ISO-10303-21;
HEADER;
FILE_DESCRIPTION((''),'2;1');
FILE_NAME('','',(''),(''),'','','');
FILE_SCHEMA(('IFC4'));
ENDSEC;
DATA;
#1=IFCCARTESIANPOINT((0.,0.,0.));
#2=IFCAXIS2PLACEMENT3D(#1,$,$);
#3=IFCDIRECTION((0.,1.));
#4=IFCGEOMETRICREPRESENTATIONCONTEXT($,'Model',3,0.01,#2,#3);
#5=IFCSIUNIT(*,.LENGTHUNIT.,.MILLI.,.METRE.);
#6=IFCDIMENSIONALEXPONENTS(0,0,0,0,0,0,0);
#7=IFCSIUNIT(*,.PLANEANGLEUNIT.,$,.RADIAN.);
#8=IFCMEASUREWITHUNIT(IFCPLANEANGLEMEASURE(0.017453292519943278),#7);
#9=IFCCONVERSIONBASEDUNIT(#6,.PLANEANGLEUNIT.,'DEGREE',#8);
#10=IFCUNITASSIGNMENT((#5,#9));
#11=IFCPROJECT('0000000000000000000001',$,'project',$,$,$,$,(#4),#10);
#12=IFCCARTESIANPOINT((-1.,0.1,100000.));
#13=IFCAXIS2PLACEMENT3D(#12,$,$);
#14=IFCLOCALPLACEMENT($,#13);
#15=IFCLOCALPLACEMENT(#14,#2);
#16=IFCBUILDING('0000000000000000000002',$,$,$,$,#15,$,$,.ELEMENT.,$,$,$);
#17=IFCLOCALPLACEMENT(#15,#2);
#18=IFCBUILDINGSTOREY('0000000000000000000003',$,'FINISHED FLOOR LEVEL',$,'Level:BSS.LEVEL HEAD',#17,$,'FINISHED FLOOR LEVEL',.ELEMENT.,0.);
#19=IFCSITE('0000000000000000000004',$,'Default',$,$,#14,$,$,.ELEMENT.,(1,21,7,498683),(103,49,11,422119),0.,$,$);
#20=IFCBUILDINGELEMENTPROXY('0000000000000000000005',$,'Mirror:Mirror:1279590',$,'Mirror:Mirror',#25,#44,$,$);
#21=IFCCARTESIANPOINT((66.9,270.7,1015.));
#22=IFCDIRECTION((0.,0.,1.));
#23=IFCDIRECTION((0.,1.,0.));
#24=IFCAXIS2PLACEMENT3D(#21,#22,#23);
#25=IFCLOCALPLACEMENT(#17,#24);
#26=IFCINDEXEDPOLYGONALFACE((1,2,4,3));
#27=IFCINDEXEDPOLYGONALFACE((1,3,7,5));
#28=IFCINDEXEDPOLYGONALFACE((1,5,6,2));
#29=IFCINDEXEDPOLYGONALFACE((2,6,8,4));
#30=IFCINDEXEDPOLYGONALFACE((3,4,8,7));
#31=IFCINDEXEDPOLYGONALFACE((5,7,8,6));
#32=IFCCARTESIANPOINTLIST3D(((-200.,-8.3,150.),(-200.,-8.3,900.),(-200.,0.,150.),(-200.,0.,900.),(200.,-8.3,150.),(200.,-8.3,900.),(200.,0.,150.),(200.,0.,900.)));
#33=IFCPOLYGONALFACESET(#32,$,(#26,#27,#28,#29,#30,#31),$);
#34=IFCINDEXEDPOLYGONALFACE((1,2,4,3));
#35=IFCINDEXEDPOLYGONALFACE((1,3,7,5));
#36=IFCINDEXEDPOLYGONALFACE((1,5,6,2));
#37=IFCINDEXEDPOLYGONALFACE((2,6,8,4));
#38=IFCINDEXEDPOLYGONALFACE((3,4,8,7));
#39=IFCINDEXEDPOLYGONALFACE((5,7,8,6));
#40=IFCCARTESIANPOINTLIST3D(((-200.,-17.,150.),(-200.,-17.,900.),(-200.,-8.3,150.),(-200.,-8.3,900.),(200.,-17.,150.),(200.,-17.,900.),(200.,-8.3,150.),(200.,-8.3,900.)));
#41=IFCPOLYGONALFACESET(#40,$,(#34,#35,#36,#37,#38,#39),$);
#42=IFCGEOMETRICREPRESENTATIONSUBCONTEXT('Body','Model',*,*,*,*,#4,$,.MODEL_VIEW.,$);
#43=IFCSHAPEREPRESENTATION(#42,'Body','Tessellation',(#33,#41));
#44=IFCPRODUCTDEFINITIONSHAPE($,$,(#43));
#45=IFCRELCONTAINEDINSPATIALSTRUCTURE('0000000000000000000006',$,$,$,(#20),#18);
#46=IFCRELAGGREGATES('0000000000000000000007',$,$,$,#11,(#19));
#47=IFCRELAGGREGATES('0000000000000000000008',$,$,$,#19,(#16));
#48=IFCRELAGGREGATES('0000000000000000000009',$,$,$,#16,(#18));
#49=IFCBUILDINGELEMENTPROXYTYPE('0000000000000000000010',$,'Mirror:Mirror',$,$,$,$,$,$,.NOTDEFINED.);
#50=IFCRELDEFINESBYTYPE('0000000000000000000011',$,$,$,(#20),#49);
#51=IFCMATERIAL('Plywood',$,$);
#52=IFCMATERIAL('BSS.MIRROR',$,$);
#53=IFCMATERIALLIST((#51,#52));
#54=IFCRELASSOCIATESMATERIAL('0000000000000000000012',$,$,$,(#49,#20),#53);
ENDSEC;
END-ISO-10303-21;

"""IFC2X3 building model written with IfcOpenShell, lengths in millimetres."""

from ifc_helpers import new_model, entity, si_unit, converted_unit, direction, frame, origin, origin_2d_with_axis, place, context, subcontext, project, spatial, rectangle, extrude, source, transform, mapped, material, material_list, type_object, type_shapes, element, save


model = new_model("IFC2X3")

# Units and contexts
model_context = context("Model", 3, precision=0.01, world=origin(), true_north=direction((0.0, 1.0)))
body_context = subcontext(model_context, "Body", "Model", "MODEL_VIEW")
ifc_project = project(units=[si_unit("LENGTHUNIT", "METRE", prefix="MILLI"), converted_unit("PLANEANGLEUNIT", "DEGREE", entity("IfcPlaneAngleMeasure", 0.017453292519943278), si_unit("PLANEANGLEUNIT", "RADIAN"), dimensions=[0, 0, 0, 0, 0, 0, 0])], contexts=[model_context])

# Site, building, storey
site_placement = place(None, frame((-1.0, 0.1, 100000.0)))
site = spatial("IfcSite", under=ifc_project, at=site_placement, Name="Default", CompositionType="ELEMENT", RefLatitude=(1, 21, 7, 498683), RefLongitude=(103, 49, 11, 422119), RefElevation=0.0)
building_placement = place(site_placement, origin())
building = spatial("IfcBuilding", under=site, at=building_placement, CompositionType="ELEMENT")
storey_placement = place(building_placement, origin())
storey = spatial("IfcBuildingStorey", under=building, at=storey_placement, Name="FINISHED FLOOR LEVEL", ObjectType="Level:BSS.LEVEL HEAD", LongName="FINISHED FLOOR LEVEL", CompositionType="ELEMENT", Elevation=0.0)

# Building element proxy
ifc_material_1 = material(Name="Plywood")
ifc_material_2 = material(Name="BSS.MIRROR")
ifc_material_list = material_list([ifc_material_1, ifc_material_2])
building_element_proxy_type = type_object("IfcBuildingElementProxyType", Name="Mirror:Mirror", PredefinedType="NOTDEFINED", material=ifc_material_list)
shared_shape = source(origin(), body_context, "Body", "SweptSolid", [
    extrude(rectangle(XDim=8.3, YDim=400.0, at=origin_2d_with_axis()), frame((0.0, -4.1, 150.0), z_axis=(0.0, 0.0, 1.0), x_axis=(0.0, 1.0, 0.0)), (0.0, 0.0, 1.0), 750.0),
    extrude(rectangle(XDim=8.7, YDim=400.0, at=origin_2d_with_axis()), frame((0.0, -12.6, 150.0), z_axis=(0.0, 0.0, 1.0), x_axis=(0.0, 1.0, 0.0)), (0.0, 0.0, 1.0), 750.0),
])
type_shapes(building_element_proxy_type, [shared_shape])
proxy_placement = place(storey_placement, frame((66.9, 270.7, 1015.0), z_axis=(0.0, 0.0, 1.0), x_axis=(0.0, 1.0, 0.0)))
element("IfcBuildingElementProxy", 1, at=proxy_placement, inside=storey, type_object=building_element_proxy_type, material=ifc_material_list, Name="Mirror:Mirror:1279590", ObjectType="Mirror:Mirror", context=body_context, shape_type="MappedRepresentation", body=[
    mapped(shared_shape, transform((0.0, 0.0, 0.0), scale=1.0)),
])

save(model, "model.ifc")
